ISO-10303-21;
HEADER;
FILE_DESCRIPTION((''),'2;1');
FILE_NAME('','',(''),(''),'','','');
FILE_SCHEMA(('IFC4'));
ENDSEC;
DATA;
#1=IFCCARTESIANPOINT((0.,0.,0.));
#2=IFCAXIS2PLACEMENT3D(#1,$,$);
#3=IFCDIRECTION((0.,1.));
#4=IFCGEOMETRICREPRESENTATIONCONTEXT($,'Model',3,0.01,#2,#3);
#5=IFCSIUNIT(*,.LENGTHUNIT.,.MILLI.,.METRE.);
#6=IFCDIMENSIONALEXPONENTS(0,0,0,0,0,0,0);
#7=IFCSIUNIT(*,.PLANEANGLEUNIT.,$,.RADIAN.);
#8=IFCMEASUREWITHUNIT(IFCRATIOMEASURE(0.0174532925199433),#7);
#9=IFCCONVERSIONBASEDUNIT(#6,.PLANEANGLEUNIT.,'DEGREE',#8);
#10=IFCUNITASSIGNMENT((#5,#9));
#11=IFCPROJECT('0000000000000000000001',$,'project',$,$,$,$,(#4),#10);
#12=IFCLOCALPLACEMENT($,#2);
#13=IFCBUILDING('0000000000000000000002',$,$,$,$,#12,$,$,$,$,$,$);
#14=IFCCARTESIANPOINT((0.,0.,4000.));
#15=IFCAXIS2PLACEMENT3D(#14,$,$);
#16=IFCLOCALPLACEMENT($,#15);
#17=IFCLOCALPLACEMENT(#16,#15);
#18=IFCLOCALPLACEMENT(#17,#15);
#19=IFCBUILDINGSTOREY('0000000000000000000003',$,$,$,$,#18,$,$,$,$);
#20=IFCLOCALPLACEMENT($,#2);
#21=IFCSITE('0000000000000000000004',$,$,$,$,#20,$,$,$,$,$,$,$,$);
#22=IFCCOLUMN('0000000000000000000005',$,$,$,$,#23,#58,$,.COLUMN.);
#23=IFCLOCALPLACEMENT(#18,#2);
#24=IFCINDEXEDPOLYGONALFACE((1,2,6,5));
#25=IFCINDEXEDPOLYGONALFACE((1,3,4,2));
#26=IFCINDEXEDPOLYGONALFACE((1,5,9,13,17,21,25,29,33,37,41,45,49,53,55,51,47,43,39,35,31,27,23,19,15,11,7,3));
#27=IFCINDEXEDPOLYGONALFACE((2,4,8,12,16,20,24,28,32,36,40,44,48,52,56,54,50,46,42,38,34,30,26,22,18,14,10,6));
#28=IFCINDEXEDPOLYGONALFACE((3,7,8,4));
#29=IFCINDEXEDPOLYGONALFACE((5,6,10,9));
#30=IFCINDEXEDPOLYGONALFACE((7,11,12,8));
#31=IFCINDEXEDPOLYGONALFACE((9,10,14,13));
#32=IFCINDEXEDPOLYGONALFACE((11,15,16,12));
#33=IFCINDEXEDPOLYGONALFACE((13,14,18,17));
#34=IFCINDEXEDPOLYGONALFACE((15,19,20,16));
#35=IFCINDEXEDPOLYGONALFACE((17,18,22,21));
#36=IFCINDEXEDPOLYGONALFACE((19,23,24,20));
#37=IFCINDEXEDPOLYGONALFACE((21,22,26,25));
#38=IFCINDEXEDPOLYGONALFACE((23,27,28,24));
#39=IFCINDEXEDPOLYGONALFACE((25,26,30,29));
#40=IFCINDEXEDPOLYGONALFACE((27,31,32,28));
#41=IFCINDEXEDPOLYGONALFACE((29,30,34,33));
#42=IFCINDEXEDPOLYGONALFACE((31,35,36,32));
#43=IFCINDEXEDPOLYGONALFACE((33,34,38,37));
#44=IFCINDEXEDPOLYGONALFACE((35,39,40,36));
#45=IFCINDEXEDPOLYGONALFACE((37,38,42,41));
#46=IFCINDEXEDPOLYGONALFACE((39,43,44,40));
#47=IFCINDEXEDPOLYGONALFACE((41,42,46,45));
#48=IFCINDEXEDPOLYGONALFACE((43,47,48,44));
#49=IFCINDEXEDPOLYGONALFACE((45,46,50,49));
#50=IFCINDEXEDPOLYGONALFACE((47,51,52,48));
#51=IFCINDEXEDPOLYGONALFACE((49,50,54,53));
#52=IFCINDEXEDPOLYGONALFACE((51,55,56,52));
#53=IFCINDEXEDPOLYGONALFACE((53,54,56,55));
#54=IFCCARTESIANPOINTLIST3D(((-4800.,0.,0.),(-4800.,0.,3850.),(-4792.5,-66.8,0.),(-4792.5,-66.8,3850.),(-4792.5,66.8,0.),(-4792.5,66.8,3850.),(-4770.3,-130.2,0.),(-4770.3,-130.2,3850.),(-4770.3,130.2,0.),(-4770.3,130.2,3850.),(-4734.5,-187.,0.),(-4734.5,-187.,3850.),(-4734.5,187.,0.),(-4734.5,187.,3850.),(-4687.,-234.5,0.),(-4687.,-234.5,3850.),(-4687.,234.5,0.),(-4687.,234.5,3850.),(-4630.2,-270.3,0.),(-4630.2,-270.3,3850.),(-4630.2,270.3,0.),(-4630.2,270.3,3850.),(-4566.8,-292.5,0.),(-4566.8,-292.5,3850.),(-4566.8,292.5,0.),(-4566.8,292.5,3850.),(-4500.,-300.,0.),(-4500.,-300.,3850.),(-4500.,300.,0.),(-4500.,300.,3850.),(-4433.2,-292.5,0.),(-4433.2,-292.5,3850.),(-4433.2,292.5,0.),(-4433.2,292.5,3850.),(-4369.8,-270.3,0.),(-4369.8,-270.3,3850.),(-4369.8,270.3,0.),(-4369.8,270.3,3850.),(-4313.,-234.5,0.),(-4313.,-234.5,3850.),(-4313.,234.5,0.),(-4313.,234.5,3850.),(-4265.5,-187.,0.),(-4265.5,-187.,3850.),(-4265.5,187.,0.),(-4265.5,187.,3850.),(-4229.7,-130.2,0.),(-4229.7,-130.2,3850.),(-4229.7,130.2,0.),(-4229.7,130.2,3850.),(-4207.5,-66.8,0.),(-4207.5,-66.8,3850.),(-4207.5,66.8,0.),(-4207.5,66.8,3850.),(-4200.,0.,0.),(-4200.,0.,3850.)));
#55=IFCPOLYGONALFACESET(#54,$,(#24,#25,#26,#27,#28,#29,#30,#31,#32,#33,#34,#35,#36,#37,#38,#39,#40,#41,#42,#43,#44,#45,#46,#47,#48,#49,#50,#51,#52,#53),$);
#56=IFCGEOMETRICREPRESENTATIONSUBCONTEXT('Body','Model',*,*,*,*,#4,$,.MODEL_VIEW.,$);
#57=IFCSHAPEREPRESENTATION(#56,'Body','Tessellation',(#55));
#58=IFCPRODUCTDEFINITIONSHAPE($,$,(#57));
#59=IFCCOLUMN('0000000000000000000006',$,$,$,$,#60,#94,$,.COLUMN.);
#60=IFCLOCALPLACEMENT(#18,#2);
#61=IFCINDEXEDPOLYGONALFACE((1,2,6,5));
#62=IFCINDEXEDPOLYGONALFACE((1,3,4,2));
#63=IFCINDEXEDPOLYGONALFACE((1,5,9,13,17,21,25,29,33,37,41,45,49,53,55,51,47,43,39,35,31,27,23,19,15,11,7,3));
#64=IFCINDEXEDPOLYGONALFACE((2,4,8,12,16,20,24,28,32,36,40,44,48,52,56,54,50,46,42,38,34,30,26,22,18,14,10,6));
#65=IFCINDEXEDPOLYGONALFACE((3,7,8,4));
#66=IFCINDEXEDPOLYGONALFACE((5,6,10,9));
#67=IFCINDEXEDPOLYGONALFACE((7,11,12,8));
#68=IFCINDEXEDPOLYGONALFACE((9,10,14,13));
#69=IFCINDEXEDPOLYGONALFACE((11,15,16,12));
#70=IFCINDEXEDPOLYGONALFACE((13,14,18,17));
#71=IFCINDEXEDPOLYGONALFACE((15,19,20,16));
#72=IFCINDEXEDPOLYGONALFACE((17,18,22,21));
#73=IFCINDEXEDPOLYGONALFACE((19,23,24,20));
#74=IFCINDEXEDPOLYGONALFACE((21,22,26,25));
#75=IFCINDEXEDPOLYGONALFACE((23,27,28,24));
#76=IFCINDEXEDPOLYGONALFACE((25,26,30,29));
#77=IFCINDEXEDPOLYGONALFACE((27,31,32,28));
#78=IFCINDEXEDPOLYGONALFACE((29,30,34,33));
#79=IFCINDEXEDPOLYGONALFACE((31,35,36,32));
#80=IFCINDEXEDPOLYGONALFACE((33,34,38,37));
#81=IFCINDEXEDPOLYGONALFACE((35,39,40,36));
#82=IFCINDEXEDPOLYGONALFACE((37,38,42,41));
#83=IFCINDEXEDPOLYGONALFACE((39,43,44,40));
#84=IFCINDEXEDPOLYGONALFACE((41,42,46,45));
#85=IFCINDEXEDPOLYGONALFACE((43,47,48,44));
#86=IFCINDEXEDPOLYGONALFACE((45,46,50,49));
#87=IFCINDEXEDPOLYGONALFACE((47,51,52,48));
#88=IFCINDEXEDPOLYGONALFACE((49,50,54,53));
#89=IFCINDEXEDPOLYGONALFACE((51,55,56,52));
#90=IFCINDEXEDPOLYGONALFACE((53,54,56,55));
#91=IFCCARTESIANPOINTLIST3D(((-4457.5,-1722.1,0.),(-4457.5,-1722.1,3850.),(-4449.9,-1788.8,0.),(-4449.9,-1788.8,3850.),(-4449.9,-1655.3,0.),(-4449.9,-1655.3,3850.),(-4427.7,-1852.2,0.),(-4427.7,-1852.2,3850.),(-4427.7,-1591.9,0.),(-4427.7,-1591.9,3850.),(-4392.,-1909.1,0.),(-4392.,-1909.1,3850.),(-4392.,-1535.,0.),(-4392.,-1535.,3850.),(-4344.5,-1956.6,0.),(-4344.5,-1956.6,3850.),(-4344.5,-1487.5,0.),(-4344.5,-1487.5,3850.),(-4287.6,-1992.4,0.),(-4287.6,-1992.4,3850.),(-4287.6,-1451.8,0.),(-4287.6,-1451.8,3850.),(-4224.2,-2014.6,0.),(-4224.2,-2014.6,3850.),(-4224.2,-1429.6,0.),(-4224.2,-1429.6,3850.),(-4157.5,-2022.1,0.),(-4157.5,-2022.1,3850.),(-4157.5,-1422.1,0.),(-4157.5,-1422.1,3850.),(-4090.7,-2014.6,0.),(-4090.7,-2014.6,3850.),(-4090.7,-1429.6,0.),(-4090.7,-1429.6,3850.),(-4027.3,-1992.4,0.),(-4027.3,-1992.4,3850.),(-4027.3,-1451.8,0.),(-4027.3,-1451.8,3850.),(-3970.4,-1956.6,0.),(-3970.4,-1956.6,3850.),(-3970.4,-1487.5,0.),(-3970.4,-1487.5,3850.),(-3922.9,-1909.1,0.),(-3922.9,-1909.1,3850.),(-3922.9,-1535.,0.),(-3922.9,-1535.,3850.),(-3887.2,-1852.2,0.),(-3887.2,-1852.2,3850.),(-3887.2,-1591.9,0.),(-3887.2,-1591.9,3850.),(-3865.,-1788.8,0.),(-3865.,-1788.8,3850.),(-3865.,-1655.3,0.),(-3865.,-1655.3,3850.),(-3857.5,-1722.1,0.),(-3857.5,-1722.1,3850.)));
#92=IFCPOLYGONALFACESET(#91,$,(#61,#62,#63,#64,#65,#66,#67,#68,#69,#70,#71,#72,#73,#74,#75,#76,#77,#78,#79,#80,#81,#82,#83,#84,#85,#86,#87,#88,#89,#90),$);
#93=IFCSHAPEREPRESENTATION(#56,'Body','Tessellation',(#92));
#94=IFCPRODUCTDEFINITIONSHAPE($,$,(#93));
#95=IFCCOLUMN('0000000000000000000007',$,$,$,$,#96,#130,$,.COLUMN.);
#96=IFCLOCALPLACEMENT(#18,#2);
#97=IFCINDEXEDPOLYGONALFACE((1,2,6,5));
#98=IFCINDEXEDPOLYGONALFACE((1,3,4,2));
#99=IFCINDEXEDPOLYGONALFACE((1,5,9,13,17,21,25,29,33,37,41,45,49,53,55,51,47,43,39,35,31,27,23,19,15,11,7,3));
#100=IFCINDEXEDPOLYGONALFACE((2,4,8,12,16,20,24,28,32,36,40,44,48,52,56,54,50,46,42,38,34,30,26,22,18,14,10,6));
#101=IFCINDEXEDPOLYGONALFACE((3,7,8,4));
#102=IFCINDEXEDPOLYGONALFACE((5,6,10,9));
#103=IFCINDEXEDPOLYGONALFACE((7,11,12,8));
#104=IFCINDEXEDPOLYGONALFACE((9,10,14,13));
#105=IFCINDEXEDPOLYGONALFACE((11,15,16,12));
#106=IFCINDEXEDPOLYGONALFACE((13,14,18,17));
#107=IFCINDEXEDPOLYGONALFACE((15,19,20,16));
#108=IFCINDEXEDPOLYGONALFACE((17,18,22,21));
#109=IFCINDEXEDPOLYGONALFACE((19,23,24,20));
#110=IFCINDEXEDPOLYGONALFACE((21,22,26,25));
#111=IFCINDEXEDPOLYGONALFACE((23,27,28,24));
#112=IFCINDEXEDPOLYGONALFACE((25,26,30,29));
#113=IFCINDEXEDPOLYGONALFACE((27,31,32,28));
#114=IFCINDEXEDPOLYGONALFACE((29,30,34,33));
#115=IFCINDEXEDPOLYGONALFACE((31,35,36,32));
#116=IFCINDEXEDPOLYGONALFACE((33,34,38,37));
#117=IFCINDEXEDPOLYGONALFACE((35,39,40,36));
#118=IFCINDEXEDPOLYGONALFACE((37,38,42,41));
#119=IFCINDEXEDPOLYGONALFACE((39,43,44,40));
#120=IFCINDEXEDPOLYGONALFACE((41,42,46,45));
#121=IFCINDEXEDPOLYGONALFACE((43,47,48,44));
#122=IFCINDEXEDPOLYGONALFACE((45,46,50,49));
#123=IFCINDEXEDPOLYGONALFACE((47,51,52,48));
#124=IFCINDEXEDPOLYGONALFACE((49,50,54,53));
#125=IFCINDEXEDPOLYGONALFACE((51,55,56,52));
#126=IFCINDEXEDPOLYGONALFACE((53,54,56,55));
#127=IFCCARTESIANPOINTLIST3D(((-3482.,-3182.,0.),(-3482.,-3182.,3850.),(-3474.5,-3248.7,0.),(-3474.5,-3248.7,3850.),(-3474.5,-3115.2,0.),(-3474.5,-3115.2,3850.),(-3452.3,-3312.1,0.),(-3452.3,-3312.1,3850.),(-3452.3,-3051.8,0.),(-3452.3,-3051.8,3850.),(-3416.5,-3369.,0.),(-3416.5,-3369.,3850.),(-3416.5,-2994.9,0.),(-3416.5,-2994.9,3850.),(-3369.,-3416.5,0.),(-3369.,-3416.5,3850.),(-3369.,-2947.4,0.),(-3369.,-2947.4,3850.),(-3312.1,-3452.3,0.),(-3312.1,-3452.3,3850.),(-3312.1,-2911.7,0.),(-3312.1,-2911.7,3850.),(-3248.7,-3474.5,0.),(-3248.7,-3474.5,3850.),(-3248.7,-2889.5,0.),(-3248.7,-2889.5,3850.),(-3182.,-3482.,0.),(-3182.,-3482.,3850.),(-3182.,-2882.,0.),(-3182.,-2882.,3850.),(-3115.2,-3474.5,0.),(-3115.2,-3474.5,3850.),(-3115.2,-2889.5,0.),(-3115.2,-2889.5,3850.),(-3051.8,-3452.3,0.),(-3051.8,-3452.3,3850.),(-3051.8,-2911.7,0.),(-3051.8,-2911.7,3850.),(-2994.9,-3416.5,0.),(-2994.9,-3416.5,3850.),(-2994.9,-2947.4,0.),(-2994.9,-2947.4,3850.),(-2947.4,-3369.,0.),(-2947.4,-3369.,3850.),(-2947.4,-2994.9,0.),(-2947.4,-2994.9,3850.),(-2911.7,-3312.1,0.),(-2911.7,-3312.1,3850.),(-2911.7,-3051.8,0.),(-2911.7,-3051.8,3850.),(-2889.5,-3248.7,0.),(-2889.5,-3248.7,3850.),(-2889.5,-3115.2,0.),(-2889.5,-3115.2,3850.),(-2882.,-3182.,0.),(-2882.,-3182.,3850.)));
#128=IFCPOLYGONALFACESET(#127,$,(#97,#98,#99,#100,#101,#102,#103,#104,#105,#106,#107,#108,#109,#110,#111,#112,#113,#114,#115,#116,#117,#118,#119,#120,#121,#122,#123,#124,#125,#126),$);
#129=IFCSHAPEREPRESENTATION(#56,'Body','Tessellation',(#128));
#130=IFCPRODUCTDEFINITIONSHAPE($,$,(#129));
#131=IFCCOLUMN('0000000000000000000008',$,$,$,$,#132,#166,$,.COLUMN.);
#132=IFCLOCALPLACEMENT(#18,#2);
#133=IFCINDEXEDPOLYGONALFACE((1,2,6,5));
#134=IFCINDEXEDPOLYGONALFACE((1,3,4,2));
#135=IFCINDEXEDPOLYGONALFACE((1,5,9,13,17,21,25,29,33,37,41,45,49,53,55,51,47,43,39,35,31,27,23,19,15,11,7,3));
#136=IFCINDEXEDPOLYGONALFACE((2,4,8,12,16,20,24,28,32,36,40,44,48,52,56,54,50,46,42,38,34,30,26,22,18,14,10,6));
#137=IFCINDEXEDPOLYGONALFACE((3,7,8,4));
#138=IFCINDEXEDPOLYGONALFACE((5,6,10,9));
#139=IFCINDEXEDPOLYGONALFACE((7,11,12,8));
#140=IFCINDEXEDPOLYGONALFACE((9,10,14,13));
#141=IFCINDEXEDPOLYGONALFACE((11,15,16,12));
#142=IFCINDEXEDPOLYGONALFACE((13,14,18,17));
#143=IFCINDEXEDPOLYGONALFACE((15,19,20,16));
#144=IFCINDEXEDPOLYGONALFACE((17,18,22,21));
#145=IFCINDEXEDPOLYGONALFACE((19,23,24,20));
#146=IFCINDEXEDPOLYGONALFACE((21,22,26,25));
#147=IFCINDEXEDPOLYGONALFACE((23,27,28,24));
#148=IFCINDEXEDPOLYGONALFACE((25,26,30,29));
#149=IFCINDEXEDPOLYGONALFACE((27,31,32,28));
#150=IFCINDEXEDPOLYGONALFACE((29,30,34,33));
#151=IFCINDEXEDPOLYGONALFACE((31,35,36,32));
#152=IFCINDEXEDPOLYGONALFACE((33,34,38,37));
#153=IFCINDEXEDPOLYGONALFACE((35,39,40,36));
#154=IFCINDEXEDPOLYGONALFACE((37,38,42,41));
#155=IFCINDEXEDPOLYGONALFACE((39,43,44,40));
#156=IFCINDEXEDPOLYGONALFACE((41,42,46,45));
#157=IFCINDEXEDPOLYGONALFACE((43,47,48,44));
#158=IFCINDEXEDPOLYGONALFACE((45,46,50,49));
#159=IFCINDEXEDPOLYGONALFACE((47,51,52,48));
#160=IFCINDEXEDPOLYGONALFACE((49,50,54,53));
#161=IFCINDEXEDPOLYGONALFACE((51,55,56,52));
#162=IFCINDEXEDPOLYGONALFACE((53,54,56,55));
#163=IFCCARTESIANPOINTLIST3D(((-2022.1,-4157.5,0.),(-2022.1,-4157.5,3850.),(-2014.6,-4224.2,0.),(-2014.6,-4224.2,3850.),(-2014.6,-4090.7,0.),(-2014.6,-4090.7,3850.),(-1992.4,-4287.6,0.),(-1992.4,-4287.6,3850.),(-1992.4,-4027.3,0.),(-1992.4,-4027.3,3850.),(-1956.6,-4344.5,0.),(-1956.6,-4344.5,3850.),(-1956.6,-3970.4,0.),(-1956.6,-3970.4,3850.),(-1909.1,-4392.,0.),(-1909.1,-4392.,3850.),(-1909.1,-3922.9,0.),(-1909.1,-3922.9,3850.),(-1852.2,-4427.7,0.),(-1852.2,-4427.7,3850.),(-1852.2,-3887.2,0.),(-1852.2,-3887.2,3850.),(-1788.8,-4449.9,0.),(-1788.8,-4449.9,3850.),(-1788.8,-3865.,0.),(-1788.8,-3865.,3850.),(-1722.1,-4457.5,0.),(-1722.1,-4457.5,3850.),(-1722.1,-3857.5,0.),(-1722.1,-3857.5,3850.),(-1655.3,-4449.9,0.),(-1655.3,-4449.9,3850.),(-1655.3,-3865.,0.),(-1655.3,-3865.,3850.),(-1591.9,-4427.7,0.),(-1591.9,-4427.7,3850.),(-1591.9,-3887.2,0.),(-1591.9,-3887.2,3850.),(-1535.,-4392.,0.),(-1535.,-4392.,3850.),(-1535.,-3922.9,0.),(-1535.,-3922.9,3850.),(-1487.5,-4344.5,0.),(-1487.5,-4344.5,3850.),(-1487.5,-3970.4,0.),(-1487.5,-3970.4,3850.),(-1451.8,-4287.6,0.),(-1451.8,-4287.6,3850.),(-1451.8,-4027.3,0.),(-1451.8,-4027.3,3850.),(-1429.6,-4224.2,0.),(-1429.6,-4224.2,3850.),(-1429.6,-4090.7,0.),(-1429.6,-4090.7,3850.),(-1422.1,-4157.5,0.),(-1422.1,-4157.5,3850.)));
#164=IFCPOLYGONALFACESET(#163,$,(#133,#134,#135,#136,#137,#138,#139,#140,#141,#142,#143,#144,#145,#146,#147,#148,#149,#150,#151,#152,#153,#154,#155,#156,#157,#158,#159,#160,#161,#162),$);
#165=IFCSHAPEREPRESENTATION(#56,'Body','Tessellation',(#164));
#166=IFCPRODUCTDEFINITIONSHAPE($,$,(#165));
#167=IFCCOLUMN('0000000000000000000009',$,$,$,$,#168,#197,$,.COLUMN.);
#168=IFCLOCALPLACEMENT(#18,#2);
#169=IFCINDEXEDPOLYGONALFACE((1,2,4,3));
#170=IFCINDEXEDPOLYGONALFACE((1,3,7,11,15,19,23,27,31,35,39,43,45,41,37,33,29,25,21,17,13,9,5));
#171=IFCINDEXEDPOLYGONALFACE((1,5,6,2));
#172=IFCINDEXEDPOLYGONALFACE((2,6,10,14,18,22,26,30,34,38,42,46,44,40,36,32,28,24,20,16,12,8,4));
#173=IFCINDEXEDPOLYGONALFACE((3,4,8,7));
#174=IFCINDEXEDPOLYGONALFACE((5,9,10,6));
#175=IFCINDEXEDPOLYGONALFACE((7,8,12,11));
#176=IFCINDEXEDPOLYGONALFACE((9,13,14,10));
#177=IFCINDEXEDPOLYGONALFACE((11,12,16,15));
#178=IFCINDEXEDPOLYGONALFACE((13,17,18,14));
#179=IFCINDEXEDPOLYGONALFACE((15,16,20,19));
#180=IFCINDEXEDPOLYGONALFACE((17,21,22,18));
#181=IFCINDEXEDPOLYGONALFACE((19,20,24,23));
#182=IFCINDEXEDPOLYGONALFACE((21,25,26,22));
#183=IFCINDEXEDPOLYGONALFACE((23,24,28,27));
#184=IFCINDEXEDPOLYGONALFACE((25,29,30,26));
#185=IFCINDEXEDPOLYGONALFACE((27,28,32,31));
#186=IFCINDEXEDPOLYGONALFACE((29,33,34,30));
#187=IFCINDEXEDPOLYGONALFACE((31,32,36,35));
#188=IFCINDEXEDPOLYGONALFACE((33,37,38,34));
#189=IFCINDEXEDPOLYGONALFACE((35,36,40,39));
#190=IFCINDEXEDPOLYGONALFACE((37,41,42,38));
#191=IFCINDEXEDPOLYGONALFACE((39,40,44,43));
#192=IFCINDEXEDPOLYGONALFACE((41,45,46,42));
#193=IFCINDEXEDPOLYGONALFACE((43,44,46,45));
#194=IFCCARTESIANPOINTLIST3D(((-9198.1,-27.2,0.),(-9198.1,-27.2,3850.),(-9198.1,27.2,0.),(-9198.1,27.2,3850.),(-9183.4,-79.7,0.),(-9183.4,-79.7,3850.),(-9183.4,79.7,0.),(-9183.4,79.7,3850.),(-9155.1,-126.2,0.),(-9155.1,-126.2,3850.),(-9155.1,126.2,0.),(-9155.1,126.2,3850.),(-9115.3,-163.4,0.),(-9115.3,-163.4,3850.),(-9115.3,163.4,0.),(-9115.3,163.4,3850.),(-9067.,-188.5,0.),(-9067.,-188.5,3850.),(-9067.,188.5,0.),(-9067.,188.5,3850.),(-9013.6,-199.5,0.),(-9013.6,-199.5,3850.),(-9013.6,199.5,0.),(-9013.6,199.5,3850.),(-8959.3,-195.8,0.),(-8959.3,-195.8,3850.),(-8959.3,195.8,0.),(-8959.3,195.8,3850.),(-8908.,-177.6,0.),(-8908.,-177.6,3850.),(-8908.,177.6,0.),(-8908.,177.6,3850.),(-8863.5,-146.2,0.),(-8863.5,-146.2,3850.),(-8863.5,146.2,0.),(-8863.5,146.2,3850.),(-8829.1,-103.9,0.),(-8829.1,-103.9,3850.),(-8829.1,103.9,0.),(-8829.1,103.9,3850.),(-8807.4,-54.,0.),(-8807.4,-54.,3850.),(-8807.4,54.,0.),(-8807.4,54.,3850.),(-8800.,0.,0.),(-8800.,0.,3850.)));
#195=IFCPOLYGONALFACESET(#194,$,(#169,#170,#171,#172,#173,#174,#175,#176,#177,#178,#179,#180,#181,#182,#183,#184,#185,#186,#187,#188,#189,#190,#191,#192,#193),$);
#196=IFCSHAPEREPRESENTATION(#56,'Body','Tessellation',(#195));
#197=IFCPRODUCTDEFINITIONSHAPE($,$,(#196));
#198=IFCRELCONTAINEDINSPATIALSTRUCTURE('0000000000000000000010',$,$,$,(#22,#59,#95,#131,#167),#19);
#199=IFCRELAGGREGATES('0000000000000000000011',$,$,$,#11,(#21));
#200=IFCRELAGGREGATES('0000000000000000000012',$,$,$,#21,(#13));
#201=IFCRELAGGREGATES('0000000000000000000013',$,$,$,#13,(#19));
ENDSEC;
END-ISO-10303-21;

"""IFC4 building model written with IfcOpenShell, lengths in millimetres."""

from ifc_helpers import new_model, entity, si_unit, converted_unit, direction, frame, origin, origin_2d, place, context, subcontext, project, spatial, circle, extrude, element, save


model = new_model("IFC4")

# Units and contexts
model_context = context("Model", 3, precision=0.01, world=origin(), true_north=direction((0.0, 1.0)))
body_context = subcontext(model_context, "Body", "Model", "MODEL_VIEW")
ifc_project = project(units=[si_unit("LENGTHUNIT", "METRE", prefix="MILLI"), converted_unit("PLANEANGLEUNIT", "DEGREE", entity("IfcRatioMeasure", 0.0174532925199433), si_unit("PLANEANGLEUNIT", "RADIAN"), dimensions=[0, 0, 0, 0, 0, 0, 0])], contexts=[model_context])

# Site, building, storey
site_placement = place(None, origin())
site = spatial("IfcSite", under=ifc_project, at=site_placement)
building_placement = place(None, origin())
building = spatial("IfcBuilding", under=site, at=building_placement)
placement_1 = place(None, frame((0.0, 0.0, 4000.0)))
placement_2 = place(placement_1, frame((0.0, 0.0, 4000.0)))
storey_placement = place(placement_2, frame((0.0, 0.0, 4000.0)))
storey = spatial("IfcBuildingStorey", under=building, at=storey_placement)

# Columns
for number, where in (
    (1, (-4500.0, 0.0, 0.0)),
    (2, (-4157.5, -1722.1, 0.0)),
    (3, (-3182.0, -3182.0, 0.0)),
    (4, (-1722.1, -4157.5, 0.0)),
):
    element("IfcColumn", number, at=place(storey_placement, frame(where)), inside=storey, PredefinedType="COLUMN", context=body_context, shape_type="SweptSolid", body=[
        extrude(circle(Radius=300.0, at=origin_2d()), origin(), (0.0, 0.0, 1.0), 3850.0),
    ])
for number, where in (
    (5, (-9000.0, 0.0, 0.0)),
):
    element("IfcColumn", number, at=place(storey_placement, frame(where)), inside=storey, PredefinedType="COLUMN", context=body_context, shape_type="SweptSolid", body=[
        extrude(circle(Radius=200.0, at=origin_2d()), origin(), (0.0, 0.0, 1.0), 3850.0),
    ])

save(model, "model.ifc")
